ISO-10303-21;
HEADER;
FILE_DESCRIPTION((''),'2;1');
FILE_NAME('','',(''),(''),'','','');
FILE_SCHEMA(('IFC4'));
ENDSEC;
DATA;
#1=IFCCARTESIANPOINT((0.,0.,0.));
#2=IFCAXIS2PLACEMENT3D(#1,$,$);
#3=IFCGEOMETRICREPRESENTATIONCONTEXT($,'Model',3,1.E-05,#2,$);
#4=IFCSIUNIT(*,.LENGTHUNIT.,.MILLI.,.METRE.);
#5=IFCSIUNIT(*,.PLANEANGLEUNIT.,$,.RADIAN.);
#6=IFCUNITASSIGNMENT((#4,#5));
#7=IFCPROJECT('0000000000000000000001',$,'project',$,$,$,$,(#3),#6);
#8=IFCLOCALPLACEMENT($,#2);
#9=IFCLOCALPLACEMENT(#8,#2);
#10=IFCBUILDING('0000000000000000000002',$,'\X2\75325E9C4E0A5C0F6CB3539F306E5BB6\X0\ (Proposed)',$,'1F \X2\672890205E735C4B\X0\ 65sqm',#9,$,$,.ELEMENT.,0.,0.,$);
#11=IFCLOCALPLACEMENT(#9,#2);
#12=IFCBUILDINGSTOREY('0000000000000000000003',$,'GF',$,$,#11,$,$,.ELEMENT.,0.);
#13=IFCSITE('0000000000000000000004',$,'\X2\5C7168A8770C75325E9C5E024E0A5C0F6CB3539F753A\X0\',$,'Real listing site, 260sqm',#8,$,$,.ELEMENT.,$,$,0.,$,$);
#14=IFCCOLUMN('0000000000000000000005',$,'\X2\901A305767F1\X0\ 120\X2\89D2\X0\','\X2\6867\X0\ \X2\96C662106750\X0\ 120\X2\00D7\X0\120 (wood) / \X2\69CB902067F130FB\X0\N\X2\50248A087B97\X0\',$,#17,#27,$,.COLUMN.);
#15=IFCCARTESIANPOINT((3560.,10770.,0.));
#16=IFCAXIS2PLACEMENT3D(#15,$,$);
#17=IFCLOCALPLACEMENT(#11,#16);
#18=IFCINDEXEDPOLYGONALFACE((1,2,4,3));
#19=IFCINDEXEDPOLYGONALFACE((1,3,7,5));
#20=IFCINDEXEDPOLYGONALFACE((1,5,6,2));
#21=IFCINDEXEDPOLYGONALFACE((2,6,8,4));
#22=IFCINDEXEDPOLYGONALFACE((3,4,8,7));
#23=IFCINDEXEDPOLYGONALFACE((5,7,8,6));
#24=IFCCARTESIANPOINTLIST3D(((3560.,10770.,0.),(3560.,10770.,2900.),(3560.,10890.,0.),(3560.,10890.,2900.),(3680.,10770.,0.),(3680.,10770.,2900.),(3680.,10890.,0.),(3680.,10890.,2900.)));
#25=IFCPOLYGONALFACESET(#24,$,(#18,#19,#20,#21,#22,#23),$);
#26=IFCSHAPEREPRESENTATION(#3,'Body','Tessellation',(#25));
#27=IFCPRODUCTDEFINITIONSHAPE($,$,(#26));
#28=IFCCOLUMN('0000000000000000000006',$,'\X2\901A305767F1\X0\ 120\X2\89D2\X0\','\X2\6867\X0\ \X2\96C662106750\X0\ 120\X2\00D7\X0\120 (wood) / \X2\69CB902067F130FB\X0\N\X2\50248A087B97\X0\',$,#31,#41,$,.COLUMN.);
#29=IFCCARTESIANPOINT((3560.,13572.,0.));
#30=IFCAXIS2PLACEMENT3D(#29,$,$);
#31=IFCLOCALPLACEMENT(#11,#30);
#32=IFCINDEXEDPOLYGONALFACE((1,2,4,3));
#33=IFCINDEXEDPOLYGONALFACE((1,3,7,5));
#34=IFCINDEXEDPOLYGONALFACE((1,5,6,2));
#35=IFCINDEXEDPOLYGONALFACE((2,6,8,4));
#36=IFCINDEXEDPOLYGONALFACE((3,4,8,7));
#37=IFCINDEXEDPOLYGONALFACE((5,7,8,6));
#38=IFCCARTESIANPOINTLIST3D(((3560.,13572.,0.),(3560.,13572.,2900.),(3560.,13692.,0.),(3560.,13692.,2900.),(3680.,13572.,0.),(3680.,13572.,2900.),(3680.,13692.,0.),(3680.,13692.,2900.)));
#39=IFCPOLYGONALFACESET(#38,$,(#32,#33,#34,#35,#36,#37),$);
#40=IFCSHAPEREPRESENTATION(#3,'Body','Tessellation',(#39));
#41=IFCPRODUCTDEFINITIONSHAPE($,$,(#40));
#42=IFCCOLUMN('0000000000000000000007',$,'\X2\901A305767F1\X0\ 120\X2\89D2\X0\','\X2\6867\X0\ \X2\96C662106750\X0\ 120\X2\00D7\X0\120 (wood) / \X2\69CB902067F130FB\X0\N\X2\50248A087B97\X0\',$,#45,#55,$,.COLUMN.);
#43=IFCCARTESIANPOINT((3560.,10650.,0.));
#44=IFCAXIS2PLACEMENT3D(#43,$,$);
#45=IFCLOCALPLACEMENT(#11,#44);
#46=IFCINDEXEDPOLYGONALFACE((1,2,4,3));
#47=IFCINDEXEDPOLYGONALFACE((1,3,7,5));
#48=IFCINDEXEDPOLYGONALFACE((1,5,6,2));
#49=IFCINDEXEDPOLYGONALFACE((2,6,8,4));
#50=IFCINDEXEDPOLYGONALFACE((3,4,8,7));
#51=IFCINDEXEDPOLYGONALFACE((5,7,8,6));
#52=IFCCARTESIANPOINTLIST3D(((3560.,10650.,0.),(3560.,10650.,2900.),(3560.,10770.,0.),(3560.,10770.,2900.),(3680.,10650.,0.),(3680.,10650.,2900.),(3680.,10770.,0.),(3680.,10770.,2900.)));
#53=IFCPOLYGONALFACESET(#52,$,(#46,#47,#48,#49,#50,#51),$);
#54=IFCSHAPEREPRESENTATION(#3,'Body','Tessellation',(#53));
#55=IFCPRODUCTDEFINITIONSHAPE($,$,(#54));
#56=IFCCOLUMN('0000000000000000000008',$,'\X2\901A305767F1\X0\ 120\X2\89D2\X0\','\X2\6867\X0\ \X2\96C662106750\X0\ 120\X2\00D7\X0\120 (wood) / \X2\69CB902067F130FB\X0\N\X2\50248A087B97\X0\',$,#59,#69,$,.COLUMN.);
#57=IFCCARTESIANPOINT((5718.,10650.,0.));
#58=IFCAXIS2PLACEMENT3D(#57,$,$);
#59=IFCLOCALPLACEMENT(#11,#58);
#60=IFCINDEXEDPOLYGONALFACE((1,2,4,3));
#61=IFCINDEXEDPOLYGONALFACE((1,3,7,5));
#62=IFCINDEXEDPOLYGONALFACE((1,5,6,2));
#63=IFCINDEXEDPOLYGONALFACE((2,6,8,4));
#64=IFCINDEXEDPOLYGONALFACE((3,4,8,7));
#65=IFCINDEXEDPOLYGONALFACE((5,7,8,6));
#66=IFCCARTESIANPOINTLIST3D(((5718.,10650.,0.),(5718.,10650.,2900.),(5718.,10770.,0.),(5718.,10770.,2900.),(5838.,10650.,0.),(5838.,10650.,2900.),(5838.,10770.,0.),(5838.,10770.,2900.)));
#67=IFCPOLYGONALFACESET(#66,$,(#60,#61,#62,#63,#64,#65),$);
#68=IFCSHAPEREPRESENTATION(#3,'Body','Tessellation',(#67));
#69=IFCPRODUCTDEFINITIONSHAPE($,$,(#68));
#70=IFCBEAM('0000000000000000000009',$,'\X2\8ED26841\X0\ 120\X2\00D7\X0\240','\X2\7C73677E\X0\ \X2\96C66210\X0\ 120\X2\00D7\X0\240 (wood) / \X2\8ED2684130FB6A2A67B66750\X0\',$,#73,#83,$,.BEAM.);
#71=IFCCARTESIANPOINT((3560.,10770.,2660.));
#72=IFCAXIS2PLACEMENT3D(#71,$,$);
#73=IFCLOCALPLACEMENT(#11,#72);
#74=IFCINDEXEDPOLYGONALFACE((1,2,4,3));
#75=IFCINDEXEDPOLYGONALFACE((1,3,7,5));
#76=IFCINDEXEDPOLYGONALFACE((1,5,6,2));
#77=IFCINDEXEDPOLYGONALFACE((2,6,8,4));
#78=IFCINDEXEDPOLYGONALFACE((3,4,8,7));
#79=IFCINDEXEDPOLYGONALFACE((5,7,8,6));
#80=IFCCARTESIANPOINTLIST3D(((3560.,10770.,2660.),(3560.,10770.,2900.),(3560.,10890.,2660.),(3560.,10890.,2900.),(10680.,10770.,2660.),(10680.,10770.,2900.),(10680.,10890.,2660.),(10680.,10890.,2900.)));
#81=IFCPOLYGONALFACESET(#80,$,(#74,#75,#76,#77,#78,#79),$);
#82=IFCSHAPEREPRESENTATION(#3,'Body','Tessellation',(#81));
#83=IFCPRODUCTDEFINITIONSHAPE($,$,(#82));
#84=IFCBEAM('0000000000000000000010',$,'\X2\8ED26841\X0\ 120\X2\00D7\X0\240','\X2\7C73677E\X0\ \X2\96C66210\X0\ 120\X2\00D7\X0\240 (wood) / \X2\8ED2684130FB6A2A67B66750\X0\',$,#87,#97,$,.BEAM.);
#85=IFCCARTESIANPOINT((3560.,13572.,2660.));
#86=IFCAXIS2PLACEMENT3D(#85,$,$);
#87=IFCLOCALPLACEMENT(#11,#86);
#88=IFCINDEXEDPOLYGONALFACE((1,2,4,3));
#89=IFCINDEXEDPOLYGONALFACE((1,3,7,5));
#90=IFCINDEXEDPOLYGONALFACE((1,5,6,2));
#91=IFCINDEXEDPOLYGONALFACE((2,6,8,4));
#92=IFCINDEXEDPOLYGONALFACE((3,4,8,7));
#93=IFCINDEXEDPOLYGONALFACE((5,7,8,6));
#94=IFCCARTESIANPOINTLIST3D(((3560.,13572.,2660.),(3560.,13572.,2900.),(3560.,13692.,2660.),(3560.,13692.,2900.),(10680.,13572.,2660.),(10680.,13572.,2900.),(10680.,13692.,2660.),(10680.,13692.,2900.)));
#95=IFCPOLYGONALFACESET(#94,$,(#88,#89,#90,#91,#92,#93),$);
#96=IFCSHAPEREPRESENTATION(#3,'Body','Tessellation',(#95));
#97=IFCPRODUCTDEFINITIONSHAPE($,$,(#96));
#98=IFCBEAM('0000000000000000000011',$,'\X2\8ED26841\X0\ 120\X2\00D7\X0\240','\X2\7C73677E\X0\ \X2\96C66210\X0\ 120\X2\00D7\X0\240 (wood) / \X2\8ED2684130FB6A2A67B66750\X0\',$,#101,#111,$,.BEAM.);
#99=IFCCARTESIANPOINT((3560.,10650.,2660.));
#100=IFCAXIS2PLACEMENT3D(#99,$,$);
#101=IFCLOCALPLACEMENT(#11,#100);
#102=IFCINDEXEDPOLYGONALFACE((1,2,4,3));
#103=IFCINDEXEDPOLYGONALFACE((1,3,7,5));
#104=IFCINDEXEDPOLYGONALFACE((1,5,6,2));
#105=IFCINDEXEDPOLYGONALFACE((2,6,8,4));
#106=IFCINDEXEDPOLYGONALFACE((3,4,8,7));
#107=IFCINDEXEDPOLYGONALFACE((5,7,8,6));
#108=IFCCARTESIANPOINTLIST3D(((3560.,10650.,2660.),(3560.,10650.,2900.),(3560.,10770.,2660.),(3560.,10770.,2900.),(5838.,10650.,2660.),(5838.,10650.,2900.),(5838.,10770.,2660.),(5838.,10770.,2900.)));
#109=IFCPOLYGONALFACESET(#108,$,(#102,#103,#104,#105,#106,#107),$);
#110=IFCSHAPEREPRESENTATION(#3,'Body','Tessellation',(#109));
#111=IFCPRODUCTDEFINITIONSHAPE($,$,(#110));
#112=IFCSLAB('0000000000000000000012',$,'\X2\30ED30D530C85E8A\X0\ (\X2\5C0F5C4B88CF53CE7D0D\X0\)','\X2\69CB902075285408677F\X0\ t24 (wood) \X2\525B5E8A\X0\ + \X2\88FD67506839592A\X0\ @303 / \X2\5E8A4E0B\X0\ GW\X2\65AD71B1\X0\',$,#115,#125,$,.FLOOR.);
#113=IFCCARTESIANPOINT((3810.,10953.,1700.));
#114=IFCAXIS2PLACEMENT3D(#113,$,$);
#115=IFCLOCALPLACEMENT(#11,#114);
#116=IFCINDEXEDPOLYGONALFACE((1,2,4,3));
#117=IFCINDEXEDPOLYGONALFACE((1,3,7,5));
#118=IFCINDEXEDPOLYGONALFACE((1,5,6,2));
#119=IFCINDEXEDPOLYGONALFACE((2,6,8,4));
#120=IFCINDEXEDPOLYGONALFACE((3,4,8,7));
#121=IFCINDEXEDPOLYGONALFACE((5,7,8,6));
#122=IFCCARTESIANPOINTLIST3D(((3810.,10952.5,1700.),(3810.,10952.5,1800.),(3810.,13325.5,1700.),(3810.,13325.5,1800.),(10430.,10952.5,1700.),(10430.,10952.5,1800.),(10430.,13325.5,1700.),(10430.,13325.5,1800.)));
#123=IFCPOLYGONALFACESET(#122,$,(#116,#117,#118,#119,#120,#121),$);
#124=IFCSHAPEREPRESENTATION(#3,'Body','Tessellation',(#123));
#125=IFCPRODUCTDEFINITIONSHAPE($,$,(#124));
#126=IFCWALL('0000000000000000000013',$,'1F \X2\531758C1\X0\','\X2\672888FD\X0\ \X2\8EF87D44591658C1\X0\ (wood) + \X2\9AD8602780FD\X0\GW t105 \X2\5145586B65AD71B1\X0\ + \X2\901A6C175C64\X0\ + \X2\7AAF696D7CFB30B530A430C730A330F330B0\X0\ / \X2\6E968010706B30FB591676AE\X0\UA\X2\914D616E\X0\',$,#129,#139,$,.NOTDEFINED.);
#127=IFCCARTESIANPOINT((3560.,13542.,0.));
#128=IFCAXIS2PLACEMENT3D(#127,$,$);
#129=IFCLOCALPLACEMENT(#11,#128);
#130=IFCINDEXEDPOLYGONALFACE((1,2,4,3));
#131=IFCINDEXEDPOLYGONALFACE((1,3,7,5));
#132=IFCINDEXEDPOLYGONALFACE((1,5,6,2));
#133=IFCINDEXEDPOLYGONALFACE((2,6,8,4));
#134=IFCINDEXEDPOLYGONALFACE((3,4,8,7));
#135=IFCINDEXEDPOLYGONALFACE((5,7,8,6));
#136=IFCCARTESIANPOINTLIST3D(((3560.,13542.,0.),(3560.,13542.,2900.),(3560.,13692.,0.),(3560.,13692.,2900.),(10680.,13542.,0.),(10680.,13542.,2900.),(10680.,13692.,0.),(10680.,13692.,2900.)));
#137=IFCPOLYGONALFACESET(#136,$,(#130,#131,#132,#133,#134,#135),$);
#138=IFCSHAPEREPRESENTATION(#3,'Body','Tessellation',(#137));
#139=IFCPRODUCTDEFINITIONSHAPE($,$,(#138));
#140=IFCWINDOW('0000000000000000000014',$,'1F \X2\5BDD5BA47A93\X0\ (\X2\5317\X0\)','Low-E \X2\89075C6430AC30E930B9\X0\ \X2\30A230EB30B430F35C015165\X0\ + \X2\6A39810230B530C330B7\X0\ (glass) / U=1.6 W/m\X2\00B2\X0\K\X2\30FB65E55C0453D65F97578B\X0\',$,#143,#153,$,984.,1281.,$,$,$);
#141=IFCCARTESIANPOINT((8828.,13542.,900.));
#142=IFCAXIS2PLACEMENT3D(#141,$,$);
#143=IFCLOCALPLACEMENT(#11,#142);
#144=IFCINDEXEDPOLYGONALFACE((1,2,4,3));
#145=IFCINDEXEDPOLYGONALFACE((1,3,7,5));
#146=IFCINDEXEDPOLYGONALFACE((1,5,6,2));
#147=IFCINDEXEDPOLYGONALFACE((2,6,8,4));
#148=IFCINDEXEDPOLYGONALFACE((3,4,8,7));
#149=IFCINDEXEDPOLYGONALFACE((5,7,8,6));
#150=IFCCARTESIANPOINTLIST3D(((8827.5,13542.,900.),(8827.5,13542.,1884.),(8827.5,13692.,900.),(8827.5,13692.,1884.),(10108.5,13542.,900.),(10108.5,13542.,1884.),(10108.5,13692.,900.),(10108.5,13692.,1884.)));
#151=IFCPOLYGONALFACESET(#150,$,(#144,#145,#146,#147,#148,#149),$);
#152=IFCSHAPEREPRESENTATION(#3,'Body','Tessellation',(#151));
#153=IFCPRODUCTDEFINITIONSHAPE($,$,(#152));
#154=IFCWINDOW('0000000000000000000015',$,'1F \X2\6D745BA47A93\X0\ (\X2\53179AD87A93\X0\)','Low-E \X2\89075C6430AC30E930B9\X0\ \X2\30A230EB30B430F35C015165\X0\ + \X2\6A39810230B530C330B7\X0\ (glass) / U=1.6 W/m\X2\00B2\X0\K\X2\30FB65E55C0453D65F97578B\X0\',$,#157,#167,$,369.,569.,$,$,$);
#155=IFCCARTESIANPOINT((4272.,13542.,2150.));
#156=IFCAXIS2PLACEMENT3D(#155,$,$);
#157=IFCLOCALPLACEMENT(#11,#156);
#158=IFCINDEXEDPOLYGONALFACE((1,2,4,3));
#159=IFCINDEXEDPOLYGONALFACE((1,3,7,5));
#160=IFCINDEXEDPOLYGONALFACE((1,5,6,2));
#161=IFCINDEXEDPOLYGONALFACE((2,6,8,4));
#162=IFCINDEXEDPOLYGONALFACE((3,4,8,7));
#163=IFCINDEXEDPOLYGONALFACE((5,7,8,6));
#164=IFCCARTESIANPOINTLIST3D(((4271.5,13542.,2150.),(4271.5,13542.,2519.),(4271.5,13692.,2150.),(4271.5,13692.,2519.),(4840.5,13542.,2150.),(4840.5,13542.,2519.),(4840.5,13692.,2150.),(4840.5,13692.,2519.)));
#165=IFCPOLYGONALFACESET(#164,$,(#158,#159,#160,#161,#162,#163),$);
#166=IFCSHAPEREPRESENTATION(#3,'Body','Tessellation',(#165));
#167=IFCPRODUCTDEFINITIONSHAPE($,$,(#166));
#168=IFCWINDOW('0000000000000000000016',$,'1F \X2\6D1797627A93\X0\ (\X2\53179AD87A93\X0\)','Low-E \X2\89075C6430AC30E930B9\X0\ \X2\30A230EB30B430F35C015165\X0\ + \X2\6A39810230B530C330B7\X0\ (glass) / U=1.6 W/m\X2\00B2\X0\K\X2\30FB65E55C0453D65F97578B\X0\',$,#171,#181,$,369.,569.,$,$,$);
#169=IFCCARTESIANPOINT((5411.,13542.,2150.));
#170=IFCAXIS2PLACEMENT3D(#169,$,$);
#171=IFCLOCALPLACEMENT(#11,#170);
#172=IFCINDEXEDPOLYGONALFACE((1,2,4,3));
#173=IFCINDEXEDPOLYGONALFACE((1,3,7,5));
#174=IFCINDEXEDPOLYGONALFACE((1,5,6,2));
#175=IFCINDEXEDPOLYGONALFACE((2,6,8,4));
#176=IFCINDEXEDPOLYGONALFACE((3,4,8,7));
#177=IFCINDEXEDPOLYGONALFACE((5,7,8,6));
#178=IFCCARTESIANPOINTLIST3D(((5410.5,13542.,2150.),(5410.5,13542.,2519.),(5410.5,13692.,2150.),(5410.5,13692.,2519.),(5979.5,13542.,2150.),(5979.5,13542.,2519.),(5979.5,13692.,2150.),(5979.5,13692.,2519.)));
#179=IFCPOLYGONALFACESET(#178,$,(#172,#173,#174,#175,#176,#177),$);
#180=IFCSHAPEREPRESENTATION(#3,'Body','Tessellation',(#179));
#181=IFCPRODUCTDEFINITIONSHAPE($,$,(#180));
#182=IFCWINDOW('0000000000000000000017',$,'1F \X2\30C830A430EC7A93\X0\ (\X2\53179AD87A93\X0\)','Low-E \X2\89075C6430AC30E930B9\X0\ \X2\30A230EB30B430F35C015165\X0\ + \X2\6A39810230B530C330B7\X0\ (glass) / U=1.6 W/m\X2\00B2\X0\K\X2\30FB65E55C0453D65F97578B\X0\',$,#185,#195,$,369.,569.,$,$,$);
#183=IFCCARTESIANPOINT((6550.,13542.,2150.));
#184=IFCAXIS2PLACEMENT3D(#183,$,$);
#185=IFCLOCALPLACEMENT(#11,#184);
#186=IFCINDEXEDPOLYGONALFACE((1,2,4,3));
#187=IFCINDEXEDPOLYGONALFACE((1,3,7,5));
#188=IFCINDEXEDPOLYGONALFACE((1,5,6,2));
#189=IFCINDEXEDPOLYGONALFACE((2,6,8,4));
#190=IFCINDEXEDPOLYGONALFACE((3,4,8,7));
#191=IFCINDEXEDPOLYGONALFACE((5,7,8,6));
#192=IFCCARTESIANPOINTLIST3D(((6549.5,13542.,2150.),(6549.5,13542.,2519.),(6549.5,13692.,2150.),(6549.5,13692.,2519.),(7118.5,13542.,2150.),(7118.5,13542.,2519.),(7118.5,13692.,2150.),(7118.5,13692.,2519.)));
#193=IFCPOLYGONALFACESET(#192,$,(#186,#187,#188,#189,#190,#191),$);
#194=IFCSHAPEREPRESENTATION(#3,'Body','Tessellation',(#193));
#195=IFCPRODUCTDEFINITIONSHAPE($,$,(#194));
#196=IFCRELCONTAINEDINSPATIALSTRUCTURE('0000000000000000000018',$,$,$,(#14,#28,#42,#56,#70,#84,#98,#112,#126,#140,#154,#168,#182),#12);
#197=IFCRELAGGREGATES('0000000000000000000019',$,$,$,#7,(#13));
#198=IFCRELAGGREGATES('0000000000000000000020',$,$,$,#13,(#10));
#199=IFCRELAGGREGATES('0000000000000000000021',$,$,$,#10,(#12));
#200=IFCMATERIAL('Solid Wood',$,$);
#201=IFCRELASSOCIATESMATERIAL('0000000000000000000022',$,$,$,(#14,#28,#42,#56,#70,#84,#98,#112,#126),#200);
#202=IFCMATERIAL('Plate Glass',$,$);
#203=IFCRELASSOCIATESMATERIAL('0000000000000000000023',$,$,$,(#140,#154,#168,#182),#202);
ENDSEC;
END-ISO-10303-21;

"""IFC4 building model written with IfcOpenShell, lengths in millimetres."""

from ifc_helpers import new_model, si_unit, frame, frame_2d, origin, place, context, project, spatial, rectangle, extrude, material, element, fill, save


model = new_model("IFC4")

# Units and contexts
model_context = context("Model", 3, precision=1e-05, world=origin())
ifc_project = project(units=[si_unit("LENGTHUNIT", "METRE", prefix="MILLI"), si_unit("PLANEANGLEUNIT", "RADIAN")], contexts=[model_context])

# Site, building, storey
site_placement = place(None, origin())
site = spatial("IfcSite", under=ifc_project, at=site_placement, Name="山梨県甲府市上小河原町", ObjectType="Real listing site, 260sqm", CompositionType="ELEMENT", RefElevation=0.0)
building_placement = place(site_placement, origin())
building = spatial("IfcBuilding", under=site, at=building_placement, Name="甲府上小河原の家 (Proposed)", ObjectType="1F 木造平屋 65sqm", CompositionType="ELEMENT", ElevationOfRefHeight=0.0, ElevationOfTerrain=0.0)
storey_placement = place(building_placement, origin())
storey = spatial("IfcBuildingStorey", under=building, at=storey_placement, Name="GF", CompositionType="ELEMENT", Elevation=0.0)

# Columns
ifc_material_1 = material(Name="Solid Wood")
column_1_placement = place(storey_placement, frame((3560.0, 10770.0, 0.0)))
element("IfcColumn", 1, at=column_1_placement, inside=storey, material=ifc_material_1, Name="通し柱 120角", Description="桧 集成材 120×120 (wood) / 構造柱・N値計算", PredefinedType="COLUMN", context=model_context, shape_type="SweptSolid", body=[
    extrude(rectangle(XDim=120.0, YDim=120.0, at=frame_2d((60.0, 60.0))), frame((3560.0, 10770.0, 0.0)), (0.0, 0.0, 1.0), 2900.0),
])
column_2_placement = place(storey_placement, frame((3560.0, 13572.0, 0.0)))
element("IfcColumn", 2, at=column_2_placement, inside=storey, material=ifc_material_1, Name="通し柱 120角", Description="桧 集成材 120×120 (wood) / 構造柱・N値計算", PredefinedType="COLUMN", context=model_context, shape_type="SweptSolid", body=[
    extrude(rectangle(XDim=120.0, YDim=120.0, at=frame_2d((60.0, 60.0))), frame((3560.0, 13572.0, 0.0)), (0.0, 0.0, 1.0), 2900.0),
])
column_3_placement = place(storey_placement, frame((3560.0, 10650.0, 0.0)))
element("IfcColumn", 3, at=column_3_placement, inside=storey, material=ifc_material_1, Name="通し柱 120角", Description="桧 集成材 120×120 (wood) / 構造柱・N値計算", PredefinedType="COLUMN", context=model_context, shape_type="SweptSolid", body=[
    extrude(rectangle(XDim=120.0, YDim=120.0, at=frame_2d((60.0, 60.0))), frame((3560.0, 10650.0, 0.0)), (0.0, 0.0, 1.0), 2900.0),
])
column_4_placement = place(storey_placement, frame((5718.0, 10650.0, 0.0)))
element("IfcColumn", 4, at=column_4_placement, inside=storey, material=ifc_material_1, Name="通し柱 120角", Description="桧 集成材 120×120 (wood) / 構造柱・N値計算", PredefinedType="COLUMN", context=model_context, shape_type="SweptSolid", body=[
    extrude(rectangle(XDim=120.0, YDim=120.0, at=frame_2d((60.0, 60.0))), frame((5718.0, 10650.0, 0.0)), (0.0, 0.0, 1.0), 2900.0),
])

# Beams
beam_1_placement = place(storey_placement, frame((3560.0, 10770.0, 2660.0)))
element("IfcBeam", 5, at=beam_1_placement, inside=storey, material=ifc_material_1, Name="軒桁 120×240", Description="米松 集成 120×240 (wood) / 軒桁・横架材", PredefinedType="BEAM", context=model_context, shape_type="SweptSolid", body=[
    extrude(rectangle(XDim=7120.0, YDim=120.0, at=frame_2d((3560.0, 60.0))), frame((3560.0, 10770.0, 2660.0)), (0.0, 0.0, 1.0), 240.0),
])
beam_2_placement = place(storey_placement, frame((3560.0, 13572.0, 2660.0)))
element("IfcBeam", 6, at=beam_2_placement, inside=storey, material=ifc_material_1, Name="軒桁 120×240", Description="米松 集成 120×240 (wood) / 軒桁・横架材", PredefinedType="BEAM", context=model_context, shape_type="SweptSolid", body=[
    extrude(rectangle(XDim=7120.0, YDim=120.0, at=frame_2d((3560.0, 60.0))), frame((3560.0, 13572.0, 2660.0)), (0.0, 0.0, 1.0), 240.0),
])
beam_3_placement = place(storey_placement, frame((3560.0, 10650.0, 2660.0)))
element("IfcBeam", 7, at=beam_3_placement, inside=storey, material=ifc_material_1, Name="軒桁 120×240", Description="米松 集成 120×240 (wood) / 軒桁・横架材", PredefinedType="BEAM", context=model_context, shape_type="SweptSolid", body=[
    extrude(rectangle(XDim=2278.0, YDim=120.0, at=frame_2d((1139.0, 60.0))), frame((3560.0, 10650.0, 2660.0)), (0.0, 0.0, 1.0), 240.0),
])

# Slab
slab_1_placement = place(storey_placement, frame((3810.0, 10953.0, 1700.0)))
element("IfcSlab", 8, at=slab_1_placement, inside=storey, material=ifc_material_1, Name="ロフト床 (小屋裏収納)", Description="構造用合板 t24 (wood) 剛床 + 製材根太 @303 / 床下 GW断熱", PredefinedType="FLOOR", context=model_context, shape_type="SweptSolid", body=[
    extrude(rectangle(XDim=6620.0, YDim=2373.0, at=frame_2d((3310.0, 1186.0))), frame((3810.0, 10953.0, 1700.0)), (0.0, 0.0, 1.0), 100.0),
])

# Wall, openings, windows
wall_1_placement = place(storey_placement, frame((3560.0, 13542.0, 0.0)))
wall_1 = element("IfcWall", 9, at=wall_1_placement, inside=storey, material=ifc_material_1, Name="1F 北壁", Description="木製 軸組外壁 (wood) + 高性能GW t105 充填断熱 + 通気層 + 窯業系サイディング / 準耐火・外皮UA配慮", PredefinedType="NOTDEFINED", context=model_context, shape_type="SweptSolid", body=[
    extrude(rectangle(XDim=7120.0, YDim=150.0, at=frame_2d((3560.0, 75.0))), frame((3560.0, 13542.0, 0.0)), (0.0, 0.0, 1.0), 2900.0),
])
opening_1_placement = place(storey_placement, frame((8828.0, 13542.0, 900.0)))
opening_1 = element("IfcOpeningElement", 10, at=opening_1_placement, cuts=wall_1, PredefinedType="NOTDEFINED", context=model_context, shape_type="SweptSolid", body=[
    extrude(rectangle(XDim=1281.0, YDim=150.0, at=frame_2d((640.0, 75.0))), frame((8828.0, 13542.0, 900.0)), (0.0, 0.0, 1.0), 984.0),
])
opening_2_placement = place(storey_placement, frame((4272.0, 13542.0, 2150.0)))
opening_2 = element("IfcOpeningElement", 11, at=opening_2_placement, cuts=wall_1, PredefinedType="NOTDEFINED", context=model_context, shape_type="SweptSolid", body=[
    extrude(rectangle(XDim=569.0, YDim=150.0, at=frame_2d((284.0, 75.0))), frame((4272.0, 13542.0, 2150.0)), (0.0, 0.0, 1.0), 369.0),
])
opening_3_placement = place(storey_placement, frame((5411.0, 13542.0, 2150.0)))
opening_3 = element("IfcOpeningElement", 12, at=opening_3_placement, cuts=wall_1, PredefinedType="NOTDEFINED", context=model_context, shape_type="SweptSolid", body=[
    extrude(rectangle(XDim=569.0, YDim=150.0, at=frame_2d((284.0, 75.0))), frame((5411.0, 13542.0, 2150.0)), (0.0, 0.0, 1.0), 369.0),
])
opening_4_placement = place(storey_placement, frame((6550.0, 13542.0, 2150.0)))
opening_4 = element("IfcOpeningElement", 13, at=opening_4_placement, cuts=wall_1, PredefinedType="NOTDEFINED", context=model_context, shape_type="SweptSolid", body=[
    extrude(rectangle(XDim=569.0, YDim=150.0, at=frame_2d((284.0, 75.0))), frame((6550.0, 13542.0, 2150.0)), (0.0, 0.0, 1.0), 369.0),
])
ifc_material_2 = material(Name="Plate Glass")
window_1_placement = place(storey_placement, frame((8828.0, 13542.0, 900.0)))
window_1 = element("IfcWindow", 14, at=window_1_placement, inside=storey, material=ifc_material_2, Name="1F 寝室窓 (北)", Description="Low-E 複層ガラス アルゴン封入 + 樹脂サッシ (glass) / U=1.6 W/m²K・日射取得型", OverallHeight=984.0, OverallWidth=1281.0, context=model_context, shape_type="SweptSolid", body=[
    extrude(rectangle(XDim=1281.0, YDim=150.0, at=frame_2d((640.0, 75.0))), frame((8828.0, 13542.0, 900.0)), (0.0, 0.0, 1.0), 984.0),
])
fill(opening_1, window_1)
window_2_placement = place(storey_placement, frame((4272.0, 13542.0, 2150.0)))
window_2 = element("IfcWindow", 15, at=window_2_placement, inside=storey, material=ifc_material_2, Name="1F 浴室窓 (北高窓)", Description="Low-E 複層ガラス アルゴン封入 + 樹脂サッシ (glass) / U=1.6 W/m²K・日射取得型", OverallHeight=369.0, OverallWidth=569.0, context=model_context, shape_type="SweptSolid", body=[
    extrude(rectangle(XDim=569.0, YDim=150.0, at=frame_2d((284.0, 75.0))), frame((4272.0, 13542.0, 2150.0)), (0.0, 0.0, 1.0), 369.0),
])
fill(opening_2, window_2)
window_3_placement = place(storey_placement, frame((5411.0, 13542.0, 2150.0)))
window_3 = element("IfcWindow", 16, at=window_3_placement, inside=storey, material=ifc_material_2, Name="1F 洗面窓 (北高窓)", Description="Low-E 複層ガラス アルゴン封入 + 樹脂サッシ (glass) / U=1.6 W/m²K・日射取得型", OverallHeight=369.0, OverallWidth=569.0, context=model_context, shape_type="SweptSolid", body=[
    extrude(rectangle(XDim=569.0, YDim=150.0, at=frame_2d((284.0, 75.0))), frame((5411.0, 13542.0, 2150.0)), (0.0, 0.0, 1.0), 369.0),
])
fill(opening_3, window_3)
window_4_placement = place(storey_placement, frame((6550.0, 13542.0, 2150.0)))
window_4 = element("IfcWindow", 17, at=window_4_placement, inside=storey, material=ifc_material_2, Name="1F トイレ窓 (北高窓)", Description="Low-E 複層ガラス アルゴン封入 + 樹脂サッシ (glass) / U=1.6 W/m²K・日射取得型", OverallHeight=369.0, OverallWidth=569.0, context=model_context, shape_type="SweptSolid", body=[
    extrude(rectangle(XDim=569.0, YDim=150.0, at=frame_2d((284.0, 75.0))), frame((6550.0, 13542.0, 2150.0)), (0.0, 0.0, 1.0), 369.0),
])
fill(opening_4, window_4)

save(model, "model.ifc")
